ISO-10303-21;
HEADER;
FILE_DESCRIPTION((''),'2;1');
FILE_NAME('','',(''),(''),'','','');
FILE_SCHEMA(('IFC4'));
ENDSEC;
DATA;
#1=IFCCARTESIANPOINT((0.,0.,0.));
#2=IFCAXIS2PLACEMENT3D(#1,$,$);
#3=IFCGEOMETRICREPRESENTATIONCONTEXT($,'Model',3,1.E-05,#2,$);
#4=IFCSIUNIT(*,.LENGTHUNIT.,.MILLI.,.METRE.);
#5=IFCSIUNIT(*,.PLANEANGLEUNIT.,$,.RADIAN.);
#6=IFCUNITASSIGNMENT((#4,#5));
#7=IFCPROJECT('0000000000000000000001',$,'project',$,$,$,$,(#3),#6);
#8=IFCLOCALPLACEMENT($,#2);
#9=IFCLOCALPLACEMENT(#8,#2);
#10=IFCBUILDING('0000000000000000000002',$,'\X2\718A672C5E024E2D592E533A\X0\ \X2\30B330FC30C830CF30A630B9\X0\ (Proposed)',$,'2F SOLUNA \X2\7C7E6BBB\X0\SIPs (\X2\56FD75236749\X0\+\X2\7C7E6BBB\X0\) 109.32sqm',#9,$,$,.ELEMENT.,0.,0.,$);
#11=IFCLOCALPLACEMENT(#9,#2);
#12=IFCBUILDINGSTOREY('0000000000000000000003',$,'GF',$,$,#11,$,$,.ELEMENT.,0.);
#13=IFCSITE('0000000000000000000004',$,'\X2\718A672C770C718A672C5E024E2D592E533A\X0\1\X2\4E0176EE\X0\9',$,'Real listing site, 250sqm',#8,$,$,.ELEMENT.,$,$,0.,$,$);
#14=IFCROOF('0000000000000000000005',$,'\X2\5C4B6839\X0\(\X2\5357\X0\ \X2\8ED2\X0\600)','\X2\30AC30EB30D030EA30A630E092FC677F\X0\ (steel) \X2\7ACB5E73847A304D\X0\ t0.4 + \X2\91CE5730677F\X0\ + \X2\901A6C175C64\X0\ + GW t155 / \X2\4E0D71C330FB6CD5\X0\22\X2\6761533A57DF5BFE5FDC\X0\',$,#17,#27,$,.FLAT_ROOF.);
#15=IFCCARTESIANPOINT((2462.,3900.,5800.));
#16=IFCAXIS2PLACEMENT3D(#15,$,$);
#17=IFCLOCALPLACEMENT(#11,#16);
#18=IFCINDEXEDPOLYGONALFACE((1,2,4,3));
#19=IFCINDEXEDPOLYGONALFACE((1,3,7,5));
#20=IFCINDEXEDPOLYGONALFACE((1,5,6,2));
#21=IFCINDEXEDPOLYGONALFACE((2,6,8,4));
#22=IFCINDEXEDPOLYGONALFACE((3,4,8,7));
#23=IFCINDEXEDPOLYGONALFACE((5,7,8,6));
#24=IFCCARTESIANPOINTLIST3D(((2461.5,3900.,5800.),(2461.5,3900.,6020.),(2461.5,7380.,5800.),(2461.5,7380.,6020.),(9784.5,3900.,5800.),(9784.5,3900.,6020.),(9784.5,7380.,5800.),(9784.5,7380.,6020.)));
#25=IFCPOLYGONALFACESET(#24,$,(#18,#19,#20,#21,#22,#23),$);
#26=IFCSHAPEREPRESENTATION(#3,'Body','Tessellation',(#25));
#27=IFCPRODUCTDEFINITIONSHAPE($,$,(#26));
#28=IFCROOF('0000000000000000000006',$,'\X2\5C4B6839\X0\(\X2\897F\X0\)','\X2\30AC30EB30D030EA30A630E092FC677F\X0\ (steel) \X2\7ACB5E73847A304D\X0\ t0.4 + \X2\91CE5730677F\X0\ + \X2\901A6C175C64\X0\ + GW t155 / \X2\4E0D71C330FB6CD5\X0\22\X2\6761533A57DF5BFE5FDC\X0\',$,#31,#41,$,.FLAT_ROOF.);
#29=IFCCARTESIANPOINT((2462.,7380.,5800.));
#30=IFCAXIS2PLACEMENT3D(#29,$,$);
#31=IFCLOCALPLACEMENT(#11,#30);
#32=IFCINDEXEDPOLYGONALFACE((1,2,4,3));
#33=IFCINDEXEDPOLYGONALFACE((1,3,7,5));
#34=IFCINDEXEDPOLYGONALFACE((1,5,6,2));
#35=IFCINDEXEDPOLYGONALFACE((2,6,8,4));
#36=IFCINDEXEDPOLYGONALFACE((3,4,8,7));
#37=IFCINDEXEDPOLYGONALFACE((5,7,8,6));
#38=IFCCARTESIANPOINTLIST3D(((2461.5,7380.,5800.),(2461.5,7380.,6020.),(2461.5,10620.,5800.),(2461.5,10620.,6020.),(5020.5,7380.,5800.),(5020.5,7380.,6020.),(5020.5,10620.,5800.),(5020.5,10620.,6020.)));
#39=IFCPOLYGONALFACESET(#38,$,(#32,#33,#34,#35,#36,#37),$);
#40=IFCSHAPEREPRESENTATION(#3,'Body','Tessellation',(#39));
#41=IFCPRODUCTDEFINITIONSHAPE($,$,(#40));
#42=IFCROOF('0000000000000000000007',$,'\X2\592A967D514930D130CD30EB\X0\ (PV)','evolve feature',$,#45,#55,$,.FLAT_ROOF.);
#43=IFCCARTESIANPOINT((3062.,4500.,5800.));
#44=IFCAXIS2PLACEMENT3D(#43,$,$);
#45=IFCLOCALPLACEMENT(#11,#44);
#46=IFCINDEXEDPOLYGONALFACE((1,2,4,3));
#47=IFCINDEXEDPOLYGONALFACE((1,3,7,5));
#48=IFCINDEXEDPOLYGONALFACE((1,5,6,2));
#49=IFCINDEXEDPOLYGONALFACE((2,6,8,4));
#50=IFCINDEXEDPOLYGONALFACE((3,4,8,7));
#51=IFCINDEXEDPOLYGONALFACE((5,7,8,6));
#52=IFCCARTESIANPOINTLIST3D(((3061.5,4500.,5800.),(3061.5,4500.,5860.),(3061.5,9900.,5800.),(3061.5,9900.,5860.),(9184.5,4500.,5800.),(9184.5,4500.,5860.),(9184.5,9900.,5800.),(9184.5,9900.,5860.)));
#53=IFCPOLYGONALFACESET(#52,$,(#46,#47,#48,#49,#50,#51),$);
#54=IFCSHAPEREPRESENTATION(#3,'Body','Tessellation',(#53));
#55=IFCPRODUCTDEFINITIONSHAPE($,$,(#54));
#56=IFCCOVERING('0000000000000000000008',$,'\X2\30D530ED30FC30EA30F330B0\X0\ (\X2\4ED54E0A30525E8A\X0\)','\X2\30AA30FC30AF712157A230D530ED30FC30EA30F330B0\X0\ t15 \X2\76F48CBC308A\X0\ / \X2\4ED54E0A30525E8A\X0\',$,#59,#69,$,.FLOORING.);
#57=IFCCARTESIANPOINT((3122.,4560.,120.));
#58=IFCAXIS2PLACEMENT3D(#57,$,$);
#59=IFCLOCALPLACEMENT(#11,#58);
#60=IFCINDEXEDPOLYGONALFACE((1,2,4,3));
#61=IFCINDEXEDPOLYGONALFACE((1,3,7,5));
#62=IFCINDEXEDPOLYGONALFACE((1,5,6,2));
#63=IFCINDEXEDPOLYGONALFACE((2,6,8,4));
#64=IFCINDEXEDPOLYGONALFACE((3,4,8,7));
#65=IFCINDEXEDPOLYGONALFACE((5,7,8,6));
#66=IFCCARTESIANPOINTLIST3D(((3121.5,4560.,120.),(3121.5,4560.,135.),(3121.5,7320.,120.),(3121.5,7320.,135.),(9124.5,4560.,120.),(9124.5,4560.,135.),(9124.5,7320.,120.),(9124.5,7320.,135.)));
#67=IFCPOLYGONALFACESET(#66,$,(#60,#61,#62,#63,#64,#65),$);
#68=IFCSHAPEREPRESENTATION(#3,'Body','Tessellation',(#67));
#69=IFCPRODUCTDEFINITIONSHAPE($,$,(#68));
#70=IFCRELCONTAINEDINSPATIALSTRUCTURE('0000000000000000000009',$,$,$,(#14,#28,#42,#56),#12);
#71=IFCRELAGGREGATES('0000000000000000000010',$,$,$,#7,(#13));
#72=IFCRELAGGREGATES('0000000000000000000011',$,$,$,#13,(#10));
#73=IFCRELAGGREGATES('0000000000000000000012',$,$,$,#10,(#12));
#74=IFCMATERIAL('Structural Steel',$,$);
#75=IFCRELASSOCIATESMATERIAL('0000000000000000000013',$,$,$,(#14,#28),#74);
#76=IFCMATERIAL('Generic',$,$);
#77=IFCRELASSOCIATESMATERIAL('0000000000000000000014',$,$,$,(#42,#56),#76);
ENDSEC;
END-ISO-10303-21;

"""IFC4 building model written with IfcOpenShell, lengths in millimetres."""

from ifc_helpers import new_model, si_unit, frame, frame_2d, origin, place, context, project, spatial, rectangle, extrude, material, element, save


model = new_model("IFC4")

# Units and contexts
model_context = context("Model", 3, precision=1e-05, world=origin())
ifc_project = project(units=[si_unit("LENGTHUNIT", "METRE", prefix="MILLI"), si_unit("PLANEANGLEUNIT", "RADIAN")], contexts=[model_context])

# Site, building, storey
site_placement = place(None, origin())
site = spatial("IfcSite", under=ifc_project, at=site_placement, Name="熊本県熊本市中央区1丁目9", ObjectType="Real listing site, 250sqm", CompositionType="ELEMENT", RefElevation=0.0)
building_placement = place(site_placement, origin())
building = spatial("IfcBuilding", under=site, at=building_placement, Name="熊本市中央区 コートハウス (Proposed)", ObjectType="2F SOLUNA 籾殻SIPs (国産杉+籾殻) 109.32sqm", CompositionType="ELEMENT", ElevationOfRefHeight=0.0, ElevationOfTerrain=0.0)
storey_placement = place(building_placement, origin())
storey = spatial("IfcBuildingStorey", under=building, at=storey_placement, Name="GF", CompositionType="ELEMENT", Elevation=0.0)

# Shared definitions
ifc_material_1 = material(Name="Generic")

# Roofs
ifc_material_2 = material(Name="Structural Steel")
roof_1_placement = place(storey_placement, frame((2462.0, 3900.0, 5800.0)))
element("IfcRoof", 1, at=roof_1_placement, inside=storey, material=ifc_material_2, Name="屋根(南 軒600)", Description="ガルバリウム鋼板 (steel) 立平葺き t0.4 + 野地板 + 通気層 + GW t155 / 不燃・法22条区域対応", PredefinedType="FLAT_ROOF", context=model_context, shape_type="SweptSolid", body=[
    extrude(rectangle(XDim=7323.0, YDim=3480.0, at=frame_2d((3661.0, 1740.0))), frame((2462.0, 3900.0, 5800.0)), (0.0, 0.0, 1.0), 220.0),
])
roof_2_placement = place(storey_placement, frame((2462.0, 7380.0, 5800.0)))
element("IfcRoof", 2, at=roof_2_placement, inside=storey, material=ifc_material_2, Name="屋根(西)", Description="ガルバリウム鋼板 (steel) 立平葺き t0.4 + 野地板 + 通気層 + GW t155 / 不燃・法22条区域対応", PredefinedType="FLAT_ROOF", context=model_context, shape_type="SweptSolid", body=[
    extrude(rectangle(XDim=2559.0, YDim=3240.0, at=frame_2d((1279.0, 1620.0))), frame((2462.0, 7380.0, 5800.0)), (0.0, 0.0, 1.0), 220.0),
])
roof_3_placement = place(storey_placement, frame((3062.0, 4500.0, 5800.0)))
element("IfcRoof", 3, at=roof_3_placement, inside=storey, material=ifc_material_1, Name="太陽光パネル (PV)", Description="evolve feature", PredefinedType="FLAT_ROOF", context=model_context, shape_type="SweptSolid", body=[
    extrude(rectangle(XDim=6123.0, YDim=5400.0, at=frame_2d((3061.0, 2700.0))), frame((3062.0, 4500.0, 5800.0)), (0.0, 0.0, 1.0), 60.0),
])

# Covering
covering_placement = place(storey_placement, frame((3122.0, 4560.0, 120.0)))
element("IfcCovering", 4, at=covering_placement, inside=storey, material=ifc_material_1, Name="フローリング (仕上げ床)", Description="オーク無垢フローリング t15 直貼り / 仕上げ床", PredefinedType="FLOORING", context=model_context, shape_type="SweptSolid", body=[
    extrude(rectangle(XDim=6003.0, YDim=2760.0, at=frame_2d((3001.0, 1380.0))), frame((3122.0, 4560.0, 120.0)), (0.0, 0.0, 1.0), 15.0),
])

save(model, "model.ifc")
